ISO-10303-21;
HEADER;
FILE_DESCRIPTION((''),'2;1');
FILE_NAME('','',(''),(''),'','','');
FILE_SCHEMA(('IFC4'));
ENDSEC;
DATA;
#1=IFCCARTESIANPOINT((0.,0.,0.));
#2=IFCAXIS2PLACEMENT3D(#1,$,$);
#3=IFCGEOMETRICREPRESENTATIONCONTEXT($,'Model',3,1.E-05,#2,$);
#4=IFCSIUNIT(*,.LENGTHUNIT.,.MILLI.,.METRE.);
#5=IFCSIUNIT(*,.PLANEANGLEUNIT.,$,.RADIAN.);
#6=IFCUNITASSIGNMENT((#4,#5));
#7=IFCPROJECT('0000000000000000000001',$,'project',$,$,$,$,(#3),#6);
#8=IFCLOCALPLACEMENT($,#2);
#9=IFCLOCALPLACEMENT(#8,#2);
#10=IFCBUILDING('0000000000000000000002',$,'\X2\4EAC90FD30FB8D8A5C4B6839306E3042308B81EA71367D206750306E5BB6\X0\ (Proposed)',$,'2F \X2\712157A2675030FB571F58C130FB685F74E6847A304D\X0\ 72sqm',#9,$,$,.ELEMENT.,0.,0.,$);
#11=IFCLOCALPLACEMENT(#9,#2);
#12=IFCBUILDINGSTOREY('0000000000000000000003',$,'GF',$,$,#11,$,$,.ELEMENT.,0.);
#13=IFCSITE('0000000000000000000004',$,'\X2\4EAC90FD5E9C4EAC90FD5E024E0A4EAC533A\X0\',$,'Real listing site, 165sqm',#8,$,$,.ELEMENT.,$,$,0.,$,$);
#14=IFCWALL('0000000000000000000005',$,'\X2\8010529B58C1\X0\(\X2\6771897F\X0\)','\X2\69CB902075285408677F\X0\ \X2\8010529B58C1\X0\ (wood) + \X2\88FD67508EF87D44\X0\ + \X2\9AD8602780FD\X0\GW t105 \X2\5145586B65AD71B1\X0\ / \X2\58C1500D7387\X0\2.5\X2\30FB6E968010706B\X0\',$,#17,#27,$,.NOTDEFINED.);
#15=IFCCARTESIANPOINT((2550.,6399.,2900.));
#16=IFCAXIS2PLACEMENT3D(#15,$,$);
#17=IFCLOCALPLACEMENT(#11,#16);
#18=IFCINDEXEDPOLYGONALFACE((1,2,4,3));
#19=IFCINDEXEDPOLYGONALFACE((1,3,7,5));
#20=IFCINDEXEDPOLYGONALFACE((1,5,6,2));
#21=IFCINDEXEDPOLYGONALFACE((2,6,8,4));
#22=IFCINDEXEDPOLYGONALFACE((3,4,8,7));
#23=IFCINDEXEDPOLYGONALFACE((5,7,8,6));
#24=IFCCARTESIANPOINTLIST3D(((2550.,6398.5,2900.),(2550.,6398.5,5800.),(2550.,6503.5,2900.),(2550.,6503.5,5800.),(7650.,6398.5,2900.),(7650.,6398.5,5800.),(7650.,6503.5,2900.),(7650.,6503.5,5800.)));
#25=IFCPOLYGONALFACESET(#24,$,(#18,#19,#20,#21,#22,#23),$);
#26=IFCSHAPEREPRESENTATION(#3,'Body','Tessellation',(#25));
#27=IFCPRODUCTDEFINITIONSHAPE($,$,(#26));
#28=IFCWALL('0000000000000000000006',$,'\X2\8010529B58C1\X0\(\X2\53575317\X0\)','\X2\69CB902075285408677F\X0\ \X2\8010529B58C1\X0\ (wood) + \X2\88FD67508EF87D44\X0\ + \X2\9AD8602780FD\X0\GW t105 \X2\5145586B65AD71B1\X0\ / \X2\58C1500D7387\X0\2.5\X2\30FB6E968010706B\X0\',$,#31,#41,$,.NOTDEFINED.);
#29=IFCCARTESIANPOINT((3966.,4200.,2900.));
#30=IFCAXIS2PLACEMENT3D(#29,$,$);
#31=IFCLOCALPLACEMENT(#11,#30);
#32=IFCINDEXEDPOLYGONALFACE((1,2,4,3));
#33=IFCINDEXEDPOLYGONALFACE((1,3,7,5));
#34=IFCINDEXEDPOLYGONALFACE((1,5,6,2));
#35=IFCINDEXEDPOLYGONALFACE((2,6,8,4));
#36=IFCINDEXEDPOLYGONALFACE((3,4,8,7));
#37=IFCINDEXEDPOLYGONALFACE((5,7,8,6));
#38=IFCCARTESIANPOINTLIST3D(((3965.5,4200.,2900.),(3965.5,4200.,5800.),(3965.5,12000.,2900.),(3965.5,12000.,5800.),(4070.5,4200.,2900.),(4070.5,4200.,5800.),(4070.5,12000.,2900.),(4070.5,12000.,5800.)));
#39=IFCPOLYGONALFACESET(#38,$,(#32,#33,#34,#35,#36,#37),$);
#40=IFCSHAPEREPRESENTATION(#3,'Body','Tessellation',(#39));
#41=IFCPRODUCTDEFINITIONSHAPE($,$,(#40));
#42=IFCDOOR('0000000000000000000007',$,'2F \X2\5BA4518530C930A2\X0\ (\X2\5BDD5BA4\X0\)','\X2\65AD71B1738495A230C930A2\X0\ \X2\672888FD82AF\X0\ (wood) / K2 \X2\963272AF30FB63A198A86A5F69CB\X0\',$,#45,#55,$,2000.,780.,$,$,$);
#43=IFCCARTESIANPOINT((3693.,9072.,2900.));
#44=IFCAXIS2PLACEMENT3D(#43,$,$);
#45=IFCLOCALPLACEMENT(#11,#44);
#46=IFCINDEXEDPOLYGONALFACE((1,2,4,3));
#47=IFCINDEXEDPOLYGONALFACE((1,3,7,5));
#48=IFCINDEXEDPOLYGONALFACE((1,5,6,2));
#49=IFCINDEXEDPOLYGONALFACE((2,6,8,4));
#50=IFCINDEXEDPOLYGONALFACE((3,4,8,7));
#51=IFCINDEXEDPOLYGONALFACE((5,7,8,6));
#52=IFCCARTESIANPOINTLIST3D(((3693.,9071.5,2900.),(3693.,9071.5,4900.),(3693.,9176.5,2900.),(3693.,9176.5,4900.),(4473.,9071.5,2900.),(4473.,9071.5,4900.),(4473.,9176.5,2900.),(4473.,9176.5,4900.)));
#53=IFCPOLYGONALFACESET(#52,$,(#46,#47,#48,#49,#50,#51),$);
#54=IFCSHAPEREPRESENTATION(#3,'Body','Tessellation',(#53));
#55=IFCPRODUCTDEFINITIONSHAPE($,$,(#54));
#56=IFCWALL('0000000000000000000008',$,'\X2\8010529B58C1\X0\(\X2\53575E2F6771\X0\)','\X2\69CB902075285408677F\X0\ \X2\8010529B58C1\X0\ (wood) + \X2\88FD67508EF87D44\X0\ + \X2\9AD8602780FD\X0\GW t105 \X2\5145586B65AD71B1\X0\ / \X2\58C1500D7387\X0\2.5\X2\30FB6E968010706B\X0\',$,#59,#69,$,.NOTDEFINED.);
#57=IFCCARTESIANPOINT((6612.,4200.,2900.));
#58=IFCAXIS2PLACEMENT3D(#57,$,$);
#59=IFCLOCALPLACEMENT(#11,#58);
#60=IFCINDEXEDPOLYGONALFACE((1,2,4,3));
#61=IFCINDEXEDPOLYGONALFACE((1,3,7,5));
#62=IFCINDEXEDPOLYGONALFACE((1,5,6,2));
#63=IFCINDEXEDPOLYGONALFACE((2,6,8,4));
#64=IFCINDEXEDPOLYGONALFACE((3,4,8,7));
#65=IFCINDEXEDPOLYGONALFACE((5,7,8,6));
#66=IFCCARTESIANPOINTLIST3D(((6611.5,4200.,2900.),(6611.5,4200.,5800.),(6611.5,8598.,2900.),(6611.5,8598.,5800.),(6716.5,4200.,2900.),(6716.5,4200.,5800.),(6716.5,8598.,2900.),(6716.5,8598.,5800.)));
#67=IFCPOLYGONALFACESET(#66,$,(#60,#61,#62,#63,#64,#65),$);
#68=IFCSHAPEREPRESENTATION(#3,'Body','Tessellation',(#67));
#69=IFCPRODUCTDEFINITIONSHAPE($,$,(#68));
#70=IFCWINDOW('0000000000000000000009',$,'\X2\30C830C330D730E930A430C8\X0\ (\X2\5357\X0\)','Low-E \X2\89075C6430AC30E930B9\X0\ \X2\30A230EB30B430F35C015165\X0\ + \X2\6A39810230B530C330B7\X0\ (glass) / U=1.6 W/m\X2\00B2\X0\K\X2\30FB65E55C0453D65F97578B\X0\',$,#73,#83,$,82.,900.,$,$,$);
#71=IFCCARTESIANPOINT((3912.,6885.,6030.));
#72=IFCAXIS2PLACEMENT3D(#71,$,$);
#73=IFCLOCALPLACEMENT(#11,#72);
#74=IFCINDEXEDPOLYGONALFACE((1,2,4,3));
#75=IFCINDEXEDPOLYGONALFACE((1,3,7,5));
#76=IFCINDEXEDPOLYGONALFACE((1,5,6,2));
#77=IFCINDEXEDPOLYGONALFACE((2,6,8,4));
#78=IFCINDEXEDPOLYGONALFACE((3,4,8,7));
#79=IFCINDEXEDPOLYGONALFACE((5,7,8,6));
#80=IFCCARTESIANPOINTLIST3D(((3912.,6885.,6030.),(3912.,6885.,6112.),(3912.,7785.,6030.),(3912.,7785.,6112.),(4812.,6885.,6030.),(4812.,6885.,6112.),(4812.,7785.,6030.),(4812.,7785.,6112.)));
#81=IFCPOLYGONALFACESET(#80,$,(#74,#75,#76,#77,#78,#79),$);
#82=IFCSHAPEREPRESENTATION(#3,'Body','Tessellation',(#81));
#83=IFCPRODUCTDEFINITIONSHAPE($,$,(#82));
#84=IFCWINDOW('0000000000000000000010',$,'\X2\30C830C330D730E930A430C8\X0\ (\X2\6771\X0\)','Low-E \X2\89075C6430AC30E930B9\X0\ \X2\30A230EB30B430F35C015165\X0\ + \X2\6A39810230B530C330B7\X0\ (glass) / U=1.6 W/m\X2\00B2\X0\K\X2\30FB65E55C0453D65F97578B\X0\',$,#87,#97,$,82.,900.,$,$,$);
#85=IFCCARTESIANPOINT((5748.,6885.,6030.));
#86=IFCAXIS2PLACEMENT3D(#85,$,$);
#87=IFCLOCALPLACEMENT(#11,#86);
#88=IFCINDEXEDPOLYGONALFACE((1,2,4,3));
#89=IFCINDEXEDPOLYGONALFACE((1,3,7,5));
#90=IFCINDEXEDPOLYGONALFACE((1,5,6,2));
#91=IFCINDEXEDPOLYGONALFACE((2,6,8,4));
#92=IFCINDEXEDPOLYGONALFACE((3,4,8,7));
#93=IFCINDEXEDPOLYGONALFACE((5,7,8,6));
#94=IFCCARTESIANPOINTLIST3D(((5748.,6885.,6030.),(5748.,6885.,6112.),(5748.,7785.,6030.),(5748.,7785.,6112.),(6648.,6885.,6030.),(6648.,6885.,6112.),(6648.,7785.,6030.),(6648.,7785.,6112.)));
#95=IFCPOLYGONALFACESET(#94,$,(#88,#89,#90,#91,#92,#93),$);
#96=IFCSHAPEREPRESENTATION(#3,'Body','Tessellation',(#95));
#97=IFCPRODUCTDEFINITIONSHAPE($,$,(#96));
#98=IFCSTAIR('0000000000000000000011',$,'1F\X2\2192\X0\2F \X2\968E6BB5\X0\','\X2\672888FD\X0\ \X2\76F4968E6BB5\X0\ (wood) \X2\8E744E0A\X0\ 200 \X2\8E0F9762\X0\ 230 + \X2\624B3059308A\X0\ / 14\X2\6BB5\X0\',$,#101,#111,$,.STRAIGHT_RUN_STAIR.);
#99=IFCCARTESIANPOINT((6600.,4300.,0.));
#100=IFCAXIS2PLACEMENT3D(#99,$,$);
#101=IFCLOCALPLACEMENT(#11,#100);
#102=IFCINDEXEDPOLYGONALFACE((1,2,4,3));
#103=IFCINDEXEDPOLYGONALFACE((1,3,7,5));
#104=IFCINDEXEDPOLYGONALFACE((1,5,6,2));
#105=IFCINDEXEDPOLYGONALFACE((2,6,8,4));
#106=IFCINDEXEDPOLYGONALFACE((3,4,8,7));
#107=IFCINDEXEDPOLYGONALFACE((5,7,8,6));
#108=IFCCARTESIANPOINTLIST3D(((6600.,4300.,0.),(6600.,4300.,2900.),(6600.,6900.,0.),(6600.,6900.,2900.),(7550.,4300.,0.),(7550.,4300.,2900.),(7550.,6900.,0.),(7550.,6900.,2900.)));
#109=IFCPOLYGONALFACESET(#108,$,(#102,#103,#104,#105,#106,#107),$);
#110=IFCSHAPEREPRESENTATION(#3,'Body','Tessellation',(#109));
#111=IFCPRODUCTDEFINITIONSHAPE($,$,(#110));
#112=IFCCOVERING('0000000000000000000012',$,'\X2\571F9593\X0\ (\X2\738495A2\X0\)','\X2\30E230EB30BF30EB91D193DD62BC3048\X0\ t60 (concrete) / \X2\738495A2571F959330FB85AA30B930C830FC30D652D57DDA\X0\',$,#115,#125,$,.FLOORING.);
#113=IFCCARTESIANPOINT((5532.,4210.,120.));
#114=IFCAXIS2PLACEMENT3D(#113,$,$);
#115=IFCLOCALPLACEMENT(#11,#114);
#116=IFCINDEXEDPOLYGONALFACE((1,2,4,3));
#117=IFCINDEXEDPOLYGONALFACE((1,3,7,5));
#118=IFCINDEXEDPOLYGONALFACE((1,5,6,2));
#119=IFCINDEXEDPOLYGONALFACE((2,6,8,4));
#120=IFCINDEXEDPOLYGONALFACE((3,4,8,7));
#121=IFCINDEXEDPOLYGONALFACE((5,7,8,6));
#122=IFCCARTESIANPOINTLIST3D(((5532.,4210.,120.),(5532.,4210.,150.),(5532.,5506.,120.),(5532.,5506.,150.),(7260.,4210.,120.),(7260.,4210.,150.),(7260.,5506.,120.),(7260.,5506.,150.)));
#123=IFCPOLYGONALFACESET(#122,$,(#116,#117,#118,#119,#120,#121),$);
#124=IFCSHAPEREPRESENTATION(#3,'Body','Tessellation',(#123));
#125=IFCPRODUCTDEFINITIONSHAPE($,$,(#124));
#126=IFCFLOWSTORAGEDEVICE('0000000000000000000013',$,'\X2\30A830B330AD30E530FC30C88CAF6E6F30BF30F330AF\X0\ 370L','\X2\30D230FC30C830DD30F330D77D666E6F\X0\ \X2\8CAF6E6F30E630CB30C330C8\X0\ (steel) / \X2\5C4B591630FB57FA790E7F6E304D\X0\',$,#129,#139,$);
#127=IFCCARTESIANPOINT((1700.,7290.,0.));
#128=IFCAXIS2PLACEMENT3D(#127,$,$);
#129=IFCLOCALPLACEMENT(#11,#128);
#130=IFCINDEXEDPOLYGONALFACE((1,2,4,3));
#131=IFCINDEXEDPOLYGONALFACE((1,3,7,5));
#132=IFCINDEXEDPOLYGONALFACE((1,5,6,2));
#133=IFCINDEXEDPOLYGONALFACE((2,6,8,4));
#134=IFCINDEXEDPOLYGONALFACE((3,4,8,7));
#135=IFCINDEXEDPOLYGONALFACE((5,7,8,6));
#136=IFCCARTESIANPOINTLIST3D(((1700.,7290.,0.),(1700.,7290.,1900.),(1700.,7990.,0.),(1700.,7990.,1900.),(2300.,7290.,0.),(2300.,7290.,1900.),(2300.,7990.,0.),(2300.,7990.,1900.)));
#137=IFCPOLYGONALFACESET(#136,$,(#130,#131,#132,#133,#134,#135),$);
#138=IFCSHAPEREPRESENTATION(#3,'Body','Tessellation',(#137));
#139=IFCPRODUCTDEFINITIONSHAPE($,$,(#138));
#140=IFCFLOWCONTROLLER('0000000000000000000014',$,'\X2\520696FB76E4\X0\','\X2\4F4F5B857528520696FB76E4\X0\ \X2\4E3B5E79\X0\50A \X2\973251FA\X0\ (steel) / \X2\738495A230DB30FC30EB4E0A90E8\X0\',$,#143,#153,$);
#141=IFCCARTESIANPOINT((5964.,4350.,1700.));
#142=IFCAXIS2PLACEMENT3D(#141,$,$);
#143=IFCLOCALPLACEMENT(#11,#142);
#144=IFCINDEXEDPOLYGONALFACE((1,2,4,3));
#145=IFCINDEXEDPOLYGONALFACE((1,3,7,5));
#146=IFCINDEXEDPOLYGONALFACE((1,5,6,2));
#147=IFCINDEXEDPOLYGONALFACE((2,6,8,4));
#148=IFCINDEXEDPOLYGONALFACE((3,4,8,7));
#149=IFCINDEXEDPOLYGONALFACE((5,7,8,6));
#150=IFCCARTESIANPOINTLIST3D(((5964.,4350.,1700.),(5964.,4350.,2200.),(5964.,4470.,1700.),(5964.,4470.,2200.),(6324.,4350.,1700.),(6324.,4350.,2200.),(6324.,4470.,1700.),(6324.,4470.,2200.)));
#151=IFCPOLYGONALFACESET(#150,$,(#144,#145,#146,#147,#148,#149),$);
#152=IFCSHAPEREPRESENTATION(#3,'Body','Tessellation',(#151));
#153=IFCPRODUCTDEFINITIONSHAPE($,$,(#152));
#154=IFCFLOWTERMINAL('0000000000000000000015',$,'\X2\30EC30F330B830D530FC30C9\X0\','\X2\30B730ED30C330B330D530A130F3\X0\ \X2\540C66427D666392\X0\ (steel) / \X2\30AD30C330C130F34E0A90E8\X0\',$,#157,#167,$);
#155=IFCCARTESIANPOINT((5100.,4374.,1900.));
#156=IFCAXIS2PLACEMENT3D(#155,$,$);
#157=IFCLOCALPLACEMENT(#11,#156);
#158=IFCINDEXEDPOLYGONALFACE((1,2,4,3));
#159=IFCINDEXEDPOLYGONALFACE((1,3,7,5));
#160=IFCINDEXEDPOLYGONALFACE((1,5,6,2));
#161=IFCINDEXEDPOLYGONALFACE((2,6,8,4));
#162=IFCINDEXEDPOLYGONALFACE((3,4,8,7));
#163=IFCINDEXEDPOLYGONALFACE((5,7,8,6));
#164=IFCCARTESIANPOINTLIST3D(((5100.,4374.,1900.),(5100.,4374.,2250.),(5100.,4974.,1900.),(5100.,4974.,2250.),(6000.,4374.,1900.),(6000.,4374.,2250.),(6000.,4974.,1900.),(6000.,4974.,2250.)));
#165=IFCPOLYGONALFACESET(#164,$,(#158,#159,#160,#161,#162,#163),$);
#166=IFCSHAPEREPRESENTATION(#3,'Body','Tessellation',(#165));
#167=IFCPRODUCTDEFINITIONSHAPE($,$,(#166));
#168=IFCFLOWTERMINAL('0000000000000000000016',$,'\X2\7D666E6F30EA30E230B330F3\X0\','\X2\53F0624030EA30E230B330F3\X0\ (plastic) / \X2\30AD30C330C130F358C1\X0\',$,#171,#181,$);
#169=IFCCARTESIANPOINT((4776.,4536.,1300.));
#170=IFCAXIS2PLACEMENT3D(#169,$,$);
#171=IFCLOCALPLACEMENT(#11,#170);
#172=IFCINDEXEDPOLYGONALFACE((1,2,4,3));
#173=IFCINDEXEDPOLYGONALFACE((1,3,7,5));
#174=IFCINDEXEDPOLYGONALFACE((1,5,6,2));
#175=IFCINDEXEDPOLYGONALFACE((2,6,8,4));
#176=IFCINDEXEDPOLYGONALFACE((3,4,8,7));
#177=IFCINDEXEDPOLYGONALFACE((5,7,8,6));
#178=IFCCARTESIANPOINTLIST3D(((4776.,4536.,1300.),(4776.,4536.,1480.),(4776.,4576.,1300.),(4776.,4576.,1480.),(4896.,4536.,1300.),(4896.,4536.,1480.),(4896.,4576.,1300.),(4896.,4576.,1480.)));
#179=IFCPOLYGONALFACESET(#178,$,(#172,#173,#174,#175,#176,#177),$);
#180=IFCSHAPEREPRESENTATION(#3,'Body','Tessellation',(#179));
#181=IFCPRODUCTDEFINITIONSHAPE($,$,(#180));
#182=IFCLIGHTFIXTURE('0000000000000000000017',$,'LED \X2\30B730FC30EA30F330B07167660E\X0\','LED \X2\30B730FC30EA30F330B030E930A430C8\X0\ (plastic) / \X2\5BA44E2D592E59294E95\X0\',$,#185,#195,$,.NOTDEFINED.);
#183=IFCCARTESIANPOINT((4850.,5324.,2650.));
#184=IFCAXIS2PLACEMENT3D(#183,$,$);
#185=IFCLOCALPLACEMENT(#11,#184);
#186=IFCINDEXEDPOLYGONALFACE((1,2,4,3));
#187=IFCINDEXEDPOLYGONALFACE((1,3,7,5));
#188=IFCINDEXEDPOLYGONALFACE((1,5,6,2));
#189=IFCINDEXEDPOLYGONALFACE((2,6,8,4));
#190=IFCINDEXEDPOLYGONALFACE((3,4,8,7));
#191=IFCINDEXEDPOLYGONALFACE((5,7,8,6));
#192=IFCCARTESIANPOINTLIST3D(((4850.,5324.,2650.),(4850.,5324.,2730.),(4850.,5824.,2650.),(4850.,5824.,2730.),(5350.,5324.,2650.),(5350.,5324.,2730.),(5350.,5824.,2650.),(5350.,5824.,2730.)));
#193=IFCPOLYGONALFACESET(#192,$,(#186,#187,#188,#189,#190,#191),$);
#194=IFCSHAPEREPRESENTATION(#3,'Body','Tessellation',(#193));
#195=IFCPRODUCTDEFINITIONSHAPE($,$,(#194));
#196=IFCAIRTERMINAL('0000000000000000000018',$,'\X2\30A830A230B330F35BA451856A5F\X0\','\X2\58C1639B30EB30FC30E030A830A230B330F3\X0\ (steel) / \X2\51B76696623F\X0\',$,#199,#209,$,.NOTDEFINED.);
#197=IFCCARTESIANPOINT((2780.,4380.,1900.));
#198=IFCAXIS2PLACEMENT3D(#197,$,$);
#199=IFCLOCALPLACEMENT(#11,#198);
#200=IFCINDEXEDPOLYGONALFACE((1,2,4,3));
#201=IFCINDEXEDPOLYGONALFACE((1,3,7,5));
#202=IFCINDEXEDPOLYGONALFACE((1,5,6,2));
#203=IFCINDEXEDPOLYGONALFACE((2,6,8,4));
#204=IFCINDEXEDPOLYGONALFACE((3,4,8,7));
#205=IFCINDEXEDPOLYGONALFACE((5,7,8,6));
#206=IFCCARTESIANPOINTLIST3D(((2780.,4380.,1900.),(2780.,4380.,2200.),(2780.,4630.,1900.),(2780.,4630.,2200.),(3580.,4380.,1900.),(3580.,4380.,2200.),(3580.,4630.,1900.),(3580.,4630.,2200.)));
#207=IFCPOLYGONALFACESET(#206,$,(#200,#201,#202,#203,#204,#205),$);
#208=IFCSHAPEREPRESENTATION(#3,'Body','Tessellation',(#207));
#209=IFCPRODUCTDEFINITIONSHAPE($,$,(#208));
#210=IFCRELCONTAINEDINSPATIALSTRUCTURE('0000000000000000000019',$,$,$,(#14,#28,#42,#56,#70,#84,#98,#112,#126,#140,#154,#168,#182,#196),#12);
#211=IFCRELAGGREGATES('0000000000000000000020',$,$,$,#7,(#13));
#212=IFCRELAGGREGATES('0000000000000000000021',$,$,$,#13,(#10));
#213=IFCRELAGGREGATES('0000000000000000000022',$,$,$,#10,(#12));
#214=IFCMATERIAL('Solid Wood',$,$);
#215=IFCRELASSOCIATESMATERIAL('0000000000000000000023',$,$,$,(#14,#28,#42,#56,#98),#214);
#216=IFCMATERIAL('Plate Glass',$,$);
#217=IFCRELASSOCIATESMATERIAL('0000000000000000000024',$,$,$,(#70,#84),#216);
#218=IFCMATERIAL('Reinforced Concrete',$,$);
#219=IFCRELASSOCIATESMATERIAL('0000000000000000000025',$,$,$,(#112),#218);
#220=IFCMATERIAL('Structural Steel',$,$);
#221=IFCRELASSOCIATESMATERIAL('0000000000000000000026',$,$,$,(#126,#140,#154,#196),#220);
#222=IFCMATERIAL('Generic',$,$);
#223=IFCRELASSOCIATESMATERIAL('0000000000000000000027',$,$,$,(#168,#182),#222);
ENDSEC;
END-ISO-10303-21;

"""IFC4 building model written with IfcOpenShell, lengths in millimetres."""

from ifc_helpers import new_model, si_unit, frame, frame_2d, origin, place, context, project, spatial, rectangle, extrude, material, element, fill, save


model = new_model("IFC4")

# Units and contexts
model_context = context("Model", 3, precision=1e-05, world=origin())
ifc_project = project(units=[si_unit("LENGTHUNIT", "METRE", prefix="MILLI"), si_unit("PLANEANGLEUNIT", "RADIAN")], contexts=[model_context])

# Site, building, storey
site_placement = place(None, origin())
site = spatial("IfcSite", under=ifc_project, at=site_placement, Name="京都府京都市上京区", ObjectType="Real listing site, 165sqm", CompositionType="ELEMENT", RefElevation=0.0)
building_placement = place(site_placement, origin())
building = spatial("IfcBuilding", under=site, at=building_placement, Name="京都・越屋根のある自然素材の家 (Proposed)", ObjectType="2F 無垢材・土壁・桟瓦葺き 72sqm", CompositionType="ELEMENT", ElevationOfRefHeight=0.0, ElevationOfTerrain=0.0)
storey_placement = place(building_placement, origin())
storey = spatial("IfcBuildingStorey", under=building, at=storey_placement, Name="GF", CompositionType="ELEMENT", Elevation=0.0)

# Shared definitions
ifc_material_1 = material(Name="Solid Wood")

# Wall
wall_1_placement = place(storey_placement, frame((2550.0, 6399.0, 2900.0)))
element("IfcWall", 1, at=wall_1_placement, inside=storey, material=ifc_material_1, Name="耐力壁(東西)", Description="構造用合板 耐力壁 (wood) + 製材軸組 + 高性能GW t105 充填断熱 / 壁倍率2.5・準耐火", PredefinedType="NOTDEFINED", context=model_context, shape_type="SweptSolid", body=[
    extrude(rectangle(XDim=5100.0, YDim=105.0, at=frame_2d((2550.0, 52.0))), frame((2550.0, 6399.0, 2900.0)), (0.0, 0.0, 1.0), 2900.0),
])

# Wall, opening, door
wall_2_placement = place(storey_placement, frame((3966.0, 4200.0, 2900.0)))
wall_2 = element("IfcWall", 2, at=wall_2_placement, inside=storey, material=ifc_material_1, Name="耐力壁(南北)", Description="構造用合板 耐力壁 (wood) + 製材軸組 + 高性能GW t105 充填断熱 / 壁倍率2.5・準耐火", PredefinedType="NOTDEFINED", context=model_context, shape_type="SweptSolid", body=[
    extrude(rectangle(XDim=105.0, YDim=7800.0, at=frame_2d((52.0, 3900.0))), frame((3966.0, 4200.0, 2900.0)), (0.0, 0.0, 1.0), 2900.0),
])
opening_placement = place(storey_placement, frame((3693.0, 9072.0, 2900.0)))
opening = element("IfcOpeningElement", 3, at=opening_placement, cuts=wall_2, PredefinedType="NOTDEFINED", context=model_context, shape_type="SweptSolid", body=[
    extrude(rectangle(XDim=780.0, YDim=105.0, at=frame_2d((390.0, 52.0))), frame((3693.0, 9072.0, 2900.0)), (0.0, 0.0, 1.0), 2000.0),
])
door_placement = place(storey_placement, frame((3693.0, 9072.0, 2900.0)))
door = element("IfcDoor", 4, at=door_placement, inside=storey, material=ifc_material_1, Name="2F 室内ドア (寝室)", Description="断熱玄関ドア 木製芯 (wood) / K2 防犯・採風機構", OverallHeight=2000.0, OverallWidth=780.0, context=model_context, shape_type="SweptSolid", body=[
    extrude(rectangle(XDim=780.0, YDim=105.0, at=frame_2d((390.0, 52.0))), frame((3693.0, 9072.0, 2900.0)), (0.0, 0.0, 1.0), 2000.0),
])
fill(opening, door)

# Wall
wall_3_placement = place(storey_placement, frame((6612.0, 4200.0, 2900.0)))
element("IfcWall", 5, at=wall_3_placement, inside=storey, material=ifc_material_1, Name="耐力壁(南帯東)", Description="構造用合板 耐力壁 (wood) + 製材軸組 + 高性能GW t105 充填断熱 / 壁倍率2.5・準耐火", PredefinedType="NOTDEFINED", context=model_context, shape_type="SweptSolid", body=[
    extrude(rectangle(XDim=105.0, YDim=4398.0, at=frame_2d((52.0, 2199.0))), frame((6612.0, 4200.0, 2900.0)), (0.0, 0.0, 1.0), 2900.0),
])

# Windows
ifc_material_2 = material(Name="Plate Glass")
window_1_placement = place(storey_placement, frame((3912.0, 6885.0, 6030.0)))
element("IfcWindow", 6, at=window_1_placement, inside=storey, material=ifc_material_2, Name="トップライト (南)", Description="Low-E 複層ガラス アルゴン封入 + 樹脂サッシ (glass) / U=1.6 W/m²K・日射取得型", OverallHeight=82.0, OverallWidth=900.0, context=model_context, shape_type="SweptSolid", body=[
    extrude(rectangle(XDim=900.0, YDim=900.0, at=frame_2d((450.0, 450.0))), frame((3912.0, 6885.0, 6030.0)), (0.0, 0.0, 1.0), 82.0),
])
window_2_placement = place(storey_placement, frame((5748.0, 6885.0, 6030.0)))
element("IfcWindow", 7, at=window_2_placement, inside=storey, material=ifc_material_2, Name="トップライト (東)", Description="Low-E 複層ガラス アルゴン封入 + 樹脂サッシ (glass) / U=1.6 W/m²K・日射取得型", OverallHeight=82.0, OverallWidth=900.0, context=model_context, shape_type="SweptSolid", body=[
    extrude(rectangle(XDim=900.0, YDim=900.0, at=frame_2d((450.0, 450.0))), frame((5748.0, 6885.0, 6030.0)), (0.0, 0.0, 1.0), 82.0),
])

# Stair
stair_placement = place(storey_placement, frame((6600.0, 4300.0, 0.0)))
element("IfcStair", 8, at=stair_placement, inside=storey, material=ifc_material_1, Name="1F→2F 階段", Description="木製 直階段 (wood) 蹴上 200 踏面 230 + 手すり / 14段", PredefinedType="STRAIGHT_RUN_STAIR", context=model_context, shape_type="SweptSolid", body=[
    extrude(rectangle(XDim=950.0, YDim=2600.0, at=frame_2d((475.0, 1300.0))), frame((6600.0, 4300.0, 0.0)), (0.0, 0.0, 1.0), 2900.0),
])

# Covering
ifc_material_3 = material(Name="Reinforced Concrete")
covering_placement = place(storey_placement, frame((5532.0, 4210.0, 120.0)))
element("IfcCovering", 9, at=covering_placement, inside=storey, material=ifc_material_3, Name="土間 (玄関)", Description="モルタル金鏝押え t60 (concrete) / 玄関土間・薪ストーブ動線", PredefinedType="FLOORING", context=model_context, shape_type="SweptSolid", body=[
    extrude(rectangle(XDim=1728.0, YDim=1296.0, at=frame_2d((864.0, 648.0))), frame((5532.0, 4210.0, 120.0)), (0.0, 0.0, 1.0), 30.0),
])

# Flow storage device
ifc_material_4 = material(Name="Structural Steel")
flow_storage_device_placement = place(storey_placement, frame((1700.0, 7290.0, 0.0)))
element("IfcFlowStorageDevice", 10, at=flow_storage_device_placement, inside=storey, material=ifc_material_4, Name="エコキュート貯湯タンク 370L", Description="ヒートポンプ給湯 貯湯ユニット (steel) / 屋外・基礎置き", context=model_context, shape_type="SweptSolid", body=[
    extrude(rectangle(XDim=600.0, YDim=700.0, at=frame_2d((300.0, 350.0))), frame((1700.0, 7290.0, 0.0)), (0.0, 0.0, 1.0), 1900.0),
])

# Flow controller
flow_controller_placement = place(storey_placement, frame((5964.0, 4350.0, 1700.0)))
element("IfcFlowController", 11, at=flow_controller_placement, inside=storey, material=ifc_material_4, Name="分電盤", Description="住宅用分電盤 主幹50A 露出 (steel) / 玄関ホール上部", context=model_context, shape_type="SweptSolid", body=[
    extrude(rectangle(XDim=360.0, YDim=120.0, at=frame_2d((180.0, 60.0))), frame((5964.0, 4350.0, 1700.0)), (0.0, 0.0, 1.0), 500.0),
])

# Flow terminals
flow_terminal_1_placement = place(storey_placement, frame((5100.0, 4374.0, 1900.0)))
element("IfcFlowTerminal", 12, at=flow_terminal_1_placement, inside=storey, material=ifc_material_4, Name="レンジフード", Description="シロッコファン 同時給排 (steel) / キッチン上部", context=model_context, shape_type="SweptSolid", body=[
    extrude(rectangle(XDim=900.0, YDim=600.0, at=frame_2d((450.0, 300.0))), frame((5100.0, 4374.0, 1900.0)), (0.0, 0.0, 1.0), 350.0),
])
ifc_material_5 = material(Name="Generic")
flow_terminal_2_placement = place(storey_placement, frame((4776.0, 4536.0, 1300.0)))
element("IfcFlowTerminal", 13, at=flow_terminal_2_placement, inside=storey, material=ifc_material_5, Name="給湯リモコン", Description="台所リモコン (plastic) / キッチン壁", context=model_context, shape_type="SweptSolid", body=[
    extrude(rectangle(XDim=120.0, YDim=40.0, at=frame_2d((60.0, 20.0))), frame((4776.0, 4536.0, 1300.0)), (0.0, 0.0, 1.0), 180.0),
])

# Light fixture
light_fixture_1_placement = place(storey_placement, frame((4850.0, 5324.0, 2650.0)))
element("IfcLightFixture", 14, at=light_fixture_1_placement, inside=storey, material=ifc_material_5, Name="LED シーリング照明", Description="LED シーリングライト (plastic) / 室中央天井", PredefinedType="NOTDEFINED", context=model_context, shape_type="SweptSolid", body=[
    extrude(rectangle(XDim=500.0, YDim=500.0, at=frame_2d((250.0, 250.0))), frame((4850.0, 5324.0, 2650.0)), (0.0, 0.0, 1.0), 80.0),
])

# Air terminal
air_terminal_1_placement = place(storey_placement, frame((2780.0, 4380.0, 1900.0)))
element("IfcAirTerminal", 15, at=air_terminal_1_placement, inside=storey, material=ifc_material_4, Name="エアコン室内機", Description="壁掛ルームエアコン (steel) / 冷暖房", PredefinedType="NOTDEFINED", context=model_context, shape_type="SweptSolid", body=[
    extrude(rectangle(XDim=800.0, YDim=250.0, at=frame_2d((400.0, 125.0))), frame((2780.0, 4380.0, 1900.0)), (0.0, 0.0, 1.0), 300.0),
])

save(model, "model.ifc")
